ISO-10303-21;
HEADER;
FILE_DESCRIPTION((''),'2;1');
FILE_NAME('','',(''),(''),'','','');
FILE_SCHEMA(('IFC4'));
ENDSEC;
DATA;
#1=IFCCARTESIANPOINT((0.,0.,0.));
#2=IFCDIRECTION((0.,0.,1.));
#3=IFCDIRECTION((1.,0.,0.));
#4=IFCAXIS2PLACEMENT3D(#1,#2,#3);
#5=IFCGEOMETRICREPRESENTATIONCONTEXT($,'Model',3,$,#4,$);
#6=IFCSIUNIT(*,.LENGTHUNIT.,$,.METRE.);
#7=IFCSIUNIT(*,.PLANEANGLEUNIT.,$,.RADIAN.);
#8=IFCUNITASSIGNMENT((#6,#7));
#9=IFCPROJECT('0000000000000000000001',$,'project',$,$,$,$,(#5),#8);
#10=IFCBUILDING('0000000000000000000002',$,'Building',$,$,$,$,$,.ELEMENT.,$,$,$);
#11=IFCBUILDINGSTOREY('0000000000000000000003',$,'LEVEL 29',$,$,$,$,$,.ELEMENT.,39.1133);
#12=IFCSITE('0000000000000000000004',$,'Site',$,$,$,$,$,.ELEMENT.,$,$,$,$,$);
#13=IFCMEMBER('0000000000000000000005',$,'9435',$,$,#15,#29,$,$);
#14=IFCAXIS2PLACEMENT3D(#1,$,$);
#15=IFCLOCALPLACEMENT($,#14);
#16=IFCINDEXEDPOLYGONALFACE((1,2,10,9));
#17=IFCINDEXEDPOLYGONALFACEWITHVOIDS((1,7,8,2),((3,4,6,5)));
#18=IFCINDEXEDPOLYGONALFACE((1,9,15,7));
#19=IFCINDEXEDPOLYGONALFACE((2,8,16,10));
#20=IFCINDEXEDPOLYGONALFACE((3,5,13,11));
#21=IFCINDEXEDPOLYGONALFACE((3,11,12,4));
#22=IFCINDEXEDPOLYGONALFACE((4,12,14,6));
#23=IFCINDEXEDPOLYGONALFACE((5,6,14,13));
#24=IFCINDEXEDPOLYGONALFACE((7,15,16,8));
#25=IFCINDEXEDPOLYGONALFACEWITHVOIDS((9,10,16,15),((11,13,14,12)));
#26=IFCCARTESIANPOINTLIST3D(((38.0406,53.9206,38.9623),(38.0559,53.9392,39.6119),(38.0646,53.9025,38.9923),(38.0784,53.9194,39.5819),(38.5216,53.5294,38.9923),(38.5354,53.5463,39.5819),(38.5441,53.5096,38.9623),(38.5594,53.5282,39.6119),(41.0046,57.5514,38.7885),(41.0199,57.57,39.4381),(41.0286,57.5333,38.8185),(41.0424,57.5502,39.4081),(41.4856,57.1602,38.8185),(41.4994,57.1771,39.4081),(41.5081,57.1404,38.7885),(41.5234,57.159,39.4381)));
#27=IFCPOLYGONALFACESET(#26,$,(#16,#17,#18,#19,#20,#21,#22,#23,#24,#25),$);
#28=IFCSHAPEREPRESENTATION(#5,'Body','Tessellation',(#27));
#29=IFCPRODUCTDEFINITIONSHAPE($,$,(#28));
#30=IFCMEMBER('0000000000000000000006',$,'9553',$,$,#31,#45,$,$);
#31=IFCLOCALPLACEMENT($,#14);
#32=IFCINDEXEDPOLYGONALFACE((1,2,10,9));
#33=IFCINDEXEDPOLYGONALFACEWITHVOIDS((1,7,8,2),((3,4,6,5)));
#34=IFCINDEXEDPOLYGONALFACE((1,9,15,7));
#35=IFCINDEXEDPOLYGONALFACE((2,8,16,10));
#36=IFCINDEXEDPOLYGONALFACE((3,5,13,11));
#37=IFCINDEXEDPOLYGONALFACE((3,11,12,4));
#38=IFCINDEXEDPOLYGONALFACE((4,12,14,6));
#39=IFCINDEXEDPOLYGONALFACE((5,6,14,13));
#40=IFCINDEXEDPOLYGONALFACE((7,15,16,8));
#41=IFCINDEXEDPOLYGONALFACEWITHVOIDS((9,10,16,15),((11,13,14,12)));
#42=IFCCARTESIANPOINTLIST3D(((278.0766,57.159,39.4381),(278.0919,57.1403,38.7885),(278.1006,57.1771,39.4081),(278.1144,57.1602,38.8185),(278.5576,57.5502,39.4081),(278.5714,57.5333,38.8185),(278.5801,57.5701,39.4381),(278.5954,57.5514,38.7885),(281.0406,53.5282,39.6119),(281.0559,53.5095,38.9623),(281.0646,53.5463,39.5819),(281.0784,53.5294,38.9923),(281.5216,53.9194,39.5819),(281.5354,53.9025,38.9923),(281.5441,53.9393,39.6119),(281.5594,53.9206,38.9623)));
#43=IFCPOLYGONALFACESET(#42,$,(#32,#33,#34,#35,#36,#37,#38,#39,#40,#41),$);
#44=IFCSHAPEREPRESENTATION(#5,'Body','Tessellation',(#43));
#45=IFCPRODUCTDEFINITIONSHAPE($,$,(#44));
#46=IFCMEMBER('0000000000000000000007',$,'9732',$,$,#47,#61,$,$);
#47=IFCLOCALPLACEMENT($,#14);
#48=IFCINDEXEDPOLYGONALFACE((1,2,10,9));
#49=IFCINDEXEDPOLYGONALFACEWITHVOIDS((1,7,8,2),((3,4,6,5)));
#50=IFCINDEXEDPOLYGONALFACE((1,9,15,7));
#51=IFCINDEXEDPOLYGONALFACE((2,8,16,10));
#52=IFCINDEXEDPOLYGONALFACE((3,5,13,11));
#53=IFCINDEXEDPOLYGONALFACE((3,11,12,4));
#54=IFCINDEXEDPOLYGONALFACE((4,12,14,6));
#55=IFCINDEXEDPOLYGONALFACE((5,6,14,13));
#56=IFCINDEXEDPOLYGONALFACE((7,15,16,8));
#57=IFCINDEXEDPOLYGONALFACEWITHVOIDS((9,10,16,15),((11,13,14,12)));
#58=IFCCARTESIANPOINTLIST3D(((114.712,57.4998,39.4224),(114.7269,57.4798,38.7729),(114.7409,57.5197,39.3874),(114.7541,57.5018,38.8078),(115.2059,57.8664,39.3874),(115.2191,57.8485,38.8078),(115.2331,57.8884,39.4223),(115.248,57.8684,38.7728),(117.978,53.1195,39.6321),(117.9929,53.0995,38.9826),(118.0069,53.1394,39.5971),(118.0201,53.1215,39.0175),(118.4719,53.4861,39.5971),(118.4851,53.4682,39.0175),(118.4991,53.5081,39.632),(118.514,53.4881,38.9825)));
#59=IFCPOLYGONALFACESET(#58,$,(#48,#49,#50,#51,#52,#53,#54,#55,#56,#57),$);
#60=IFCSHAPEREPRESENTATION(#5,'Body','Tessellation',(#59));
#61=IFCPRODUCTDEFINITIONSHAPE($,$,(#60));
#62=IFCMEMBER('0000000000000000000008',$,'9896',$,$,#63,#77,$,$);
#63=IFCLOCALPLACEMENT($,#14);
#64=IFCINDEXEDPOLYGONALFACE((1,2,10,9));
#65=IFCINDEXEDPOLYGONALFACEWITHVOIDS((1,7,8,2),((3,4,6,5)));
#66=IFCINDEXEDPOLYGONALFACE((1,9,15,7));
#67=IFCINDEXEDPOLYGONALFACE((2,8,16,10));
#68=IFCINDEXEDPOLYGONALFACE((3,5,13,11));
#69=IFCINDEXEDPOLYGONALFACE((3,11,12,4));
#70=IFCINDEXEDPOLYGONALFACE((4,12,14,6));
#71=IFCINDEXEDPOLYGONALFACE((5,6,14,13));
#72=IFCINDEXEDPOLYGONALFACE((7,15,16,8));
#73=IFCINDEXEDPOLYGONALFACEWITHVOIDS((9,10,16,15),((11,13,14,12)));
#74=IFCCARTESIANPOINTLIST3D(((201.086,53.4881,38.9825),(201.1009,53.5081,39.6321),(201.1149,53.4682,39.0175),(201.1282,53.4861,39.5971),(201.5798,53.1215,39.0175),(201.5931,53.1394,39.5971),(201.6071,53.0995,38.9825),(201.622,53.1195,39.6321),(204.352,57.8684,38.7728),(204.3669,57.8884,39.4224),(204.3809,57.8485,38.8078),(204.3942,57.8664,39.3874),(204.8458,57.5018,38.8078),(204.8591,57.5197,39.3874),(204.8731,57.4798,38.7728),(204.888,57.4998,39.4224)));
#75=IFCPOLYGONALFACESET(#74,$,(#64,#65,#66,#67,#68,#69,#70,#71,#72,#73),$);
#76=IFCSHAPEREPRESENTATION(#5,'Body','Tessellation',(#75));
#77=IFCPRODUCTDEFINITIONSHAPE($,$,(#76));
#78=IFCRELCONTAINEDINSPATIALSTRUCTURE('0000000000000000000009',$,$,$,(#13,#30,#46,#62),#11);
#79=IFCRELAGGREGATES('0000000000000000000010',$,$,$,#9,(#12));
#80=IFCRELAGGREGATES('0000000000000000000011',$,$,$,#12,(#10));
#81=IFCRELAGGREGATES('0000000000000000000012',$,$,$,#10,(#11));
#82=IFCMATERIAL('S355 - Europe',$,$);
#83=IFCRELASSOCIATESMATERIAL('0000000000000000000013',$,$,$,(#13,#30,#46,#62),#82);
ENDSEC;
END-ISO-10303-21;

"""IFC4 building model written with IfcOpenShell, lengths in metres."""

from ifc_helpers import new_model, si_unit, frame, origin_with_axes, origin_2d_with_axis, place, context, project, spatial, hollow_rectangle, extrude, material, material_profile, profile_set, profile_usage, element, save


model = new_model("IFC4")

# Units and contexts
model_context = context("Model", 3, world=origin_with_axes())
ifc_project = project(units=[si_unit("LENGTHUNIT", "METRE"), si_unit("PLANEANGLEUNIT", "RADIAN")], contexts=[model_context])

# Site, building, storey
site = spatial("IfcSite", under=ifc_project, Name="Site", CompositionType="ELEMENT")
building = spatial("IfcBuilding", under=site, Name="Building", CompositionType="ELEMENT")
storey = spatial("IfcBuildingStorey", under=building, Name="LEVEL 29", CompositionType="ELEMENT", Elevation=39.1133)

# Members
ifc_material = material(Name="S355 - Europe")
ifc_material_profile_1 = material_profile(ifc_material, hollow_rectangle(XDim=0.65, YDim=0.65, WallThickness=0.03, at=origin_2d_with_axis()))
ifc_profile_set_1 = profile_set([ifc_material_profile_1])
ifc_profile_usage_1 = profile_usage(ifc_profile_set_1, cardinal=10)
member_1_placement = place(None, frame((38.3, 53.7244, 39.2871), z_axis=(0.631953, 0.774121, -0.037056), x_axis=(-0.773962, 0.633232, 0.0)))
element("IfcMember", 1, at=member_1_placement, inside=storey, material=ifc_profile_usage_1, Name="9435", context=model_context, shape_type="SweptSolid", body=[
    extrude(hollow_rectangle(XDim=0.65, YDim=0.65, WallThickness=0.03, at=origin_2d_with_axis()), origin_with_axes(), (0.0, 0.0, 1.0), 4.6902),
])
ifc_material_profile_2 = material_profile(ifc_material, hollow_rectangle(XDim=0.65, YDim=0.65, WallThickness=0.03, at=origin_2d_with_axis()))
ifc_profile_set_2 = profile_set([ifc_material_profile_2])
ifc_profile_usage_2 = profile_usage(ifc_profile_set_2, cardinal=10)
member_2_placement = place(None, frame((281.3, 53.7244, 39.2871), z_axis=(-0.631953, 0.774121, -0.037056), x_axis=(-0.774653, -0.632387, 0.0)))
element("IfcMember", 2, at=member_2_placement, inside=storey, material=ifc_profile_usage_2, Name="9553", context=model_context, shape_type="SweptSolid", body=[
    extrude(hollow_rectangle(XDim=0.65, YDim=0.65, WallThickness=0.03, at=origin_2d_with_axis()), origin_with_axes(), (0.0, 0.0, 1.0), 4.6902),
])
ifc_material_profile_3 = material_profile(ifc_material, hollow_rectangle(XDim=0.65, YDim=0.65, WallThickness=0.035, at=origin_2d_with_axis()))
ifc_profile_set_3 = profile_set([ifc_material_profile_3])
ifc_profile_usage_3 = profile_usage(ifc_profile_set_3, cardinal=10)
member_3_placement = place(None, frame((118.246, 53.3038, 39.3073), z_axis=(-0.597306, 0.801096, -0.038351), x_axis=(-0.802364, -0.596835, 0.0)))
element("IfcMember", 3, at=member_3_placement, inside=storey, material=ifc_profile_usage_3, Name="9732", context=model_context, shape_type="SweptSolid", body=[
    extrude(hollow_rectangle(XDim=0.65, YDim=0.65, WallThickness=0.035, at=origin_2d_with_axis()), origin_with_axes(), (0.0, 0.0, 1.0), 5.4679),
])
ifc_material_profile_4 = material_profile(ifc_material, hollow_rectangle(XDim=0.65, YDim=0.65, WallThickness=0.035, at=origin_2d_with_axis()))
ifc_profile_set_4 = profile_set([ifc_material_profile_4])
ifc_profile_usage_4 = profile_usage(ifc_profile_set_4, cardinal=10)
member_4_placement = place(None, frame((201.354, 53.3038, 39.3073), z_axis=(0.597306, 0.801096, -0.038351), x_axis=(-0.801686, 0.597746, 0.0)))
element("IfcMember", 4, at=member_4_placement, inside=storey, material=ifc_profile_usage_4, Name="9896", context=model_context, shape_type="SweptSolid", body=[
    extrude(hollow_rectangle(XDim=0.65, YDim=0.65, WallThickness=0.035, at=origin_2d_with_axis()), origin_with_axes(), (0.0, 0.0, 1.0), 5.4679),
])

save(model, "model.ifc")
